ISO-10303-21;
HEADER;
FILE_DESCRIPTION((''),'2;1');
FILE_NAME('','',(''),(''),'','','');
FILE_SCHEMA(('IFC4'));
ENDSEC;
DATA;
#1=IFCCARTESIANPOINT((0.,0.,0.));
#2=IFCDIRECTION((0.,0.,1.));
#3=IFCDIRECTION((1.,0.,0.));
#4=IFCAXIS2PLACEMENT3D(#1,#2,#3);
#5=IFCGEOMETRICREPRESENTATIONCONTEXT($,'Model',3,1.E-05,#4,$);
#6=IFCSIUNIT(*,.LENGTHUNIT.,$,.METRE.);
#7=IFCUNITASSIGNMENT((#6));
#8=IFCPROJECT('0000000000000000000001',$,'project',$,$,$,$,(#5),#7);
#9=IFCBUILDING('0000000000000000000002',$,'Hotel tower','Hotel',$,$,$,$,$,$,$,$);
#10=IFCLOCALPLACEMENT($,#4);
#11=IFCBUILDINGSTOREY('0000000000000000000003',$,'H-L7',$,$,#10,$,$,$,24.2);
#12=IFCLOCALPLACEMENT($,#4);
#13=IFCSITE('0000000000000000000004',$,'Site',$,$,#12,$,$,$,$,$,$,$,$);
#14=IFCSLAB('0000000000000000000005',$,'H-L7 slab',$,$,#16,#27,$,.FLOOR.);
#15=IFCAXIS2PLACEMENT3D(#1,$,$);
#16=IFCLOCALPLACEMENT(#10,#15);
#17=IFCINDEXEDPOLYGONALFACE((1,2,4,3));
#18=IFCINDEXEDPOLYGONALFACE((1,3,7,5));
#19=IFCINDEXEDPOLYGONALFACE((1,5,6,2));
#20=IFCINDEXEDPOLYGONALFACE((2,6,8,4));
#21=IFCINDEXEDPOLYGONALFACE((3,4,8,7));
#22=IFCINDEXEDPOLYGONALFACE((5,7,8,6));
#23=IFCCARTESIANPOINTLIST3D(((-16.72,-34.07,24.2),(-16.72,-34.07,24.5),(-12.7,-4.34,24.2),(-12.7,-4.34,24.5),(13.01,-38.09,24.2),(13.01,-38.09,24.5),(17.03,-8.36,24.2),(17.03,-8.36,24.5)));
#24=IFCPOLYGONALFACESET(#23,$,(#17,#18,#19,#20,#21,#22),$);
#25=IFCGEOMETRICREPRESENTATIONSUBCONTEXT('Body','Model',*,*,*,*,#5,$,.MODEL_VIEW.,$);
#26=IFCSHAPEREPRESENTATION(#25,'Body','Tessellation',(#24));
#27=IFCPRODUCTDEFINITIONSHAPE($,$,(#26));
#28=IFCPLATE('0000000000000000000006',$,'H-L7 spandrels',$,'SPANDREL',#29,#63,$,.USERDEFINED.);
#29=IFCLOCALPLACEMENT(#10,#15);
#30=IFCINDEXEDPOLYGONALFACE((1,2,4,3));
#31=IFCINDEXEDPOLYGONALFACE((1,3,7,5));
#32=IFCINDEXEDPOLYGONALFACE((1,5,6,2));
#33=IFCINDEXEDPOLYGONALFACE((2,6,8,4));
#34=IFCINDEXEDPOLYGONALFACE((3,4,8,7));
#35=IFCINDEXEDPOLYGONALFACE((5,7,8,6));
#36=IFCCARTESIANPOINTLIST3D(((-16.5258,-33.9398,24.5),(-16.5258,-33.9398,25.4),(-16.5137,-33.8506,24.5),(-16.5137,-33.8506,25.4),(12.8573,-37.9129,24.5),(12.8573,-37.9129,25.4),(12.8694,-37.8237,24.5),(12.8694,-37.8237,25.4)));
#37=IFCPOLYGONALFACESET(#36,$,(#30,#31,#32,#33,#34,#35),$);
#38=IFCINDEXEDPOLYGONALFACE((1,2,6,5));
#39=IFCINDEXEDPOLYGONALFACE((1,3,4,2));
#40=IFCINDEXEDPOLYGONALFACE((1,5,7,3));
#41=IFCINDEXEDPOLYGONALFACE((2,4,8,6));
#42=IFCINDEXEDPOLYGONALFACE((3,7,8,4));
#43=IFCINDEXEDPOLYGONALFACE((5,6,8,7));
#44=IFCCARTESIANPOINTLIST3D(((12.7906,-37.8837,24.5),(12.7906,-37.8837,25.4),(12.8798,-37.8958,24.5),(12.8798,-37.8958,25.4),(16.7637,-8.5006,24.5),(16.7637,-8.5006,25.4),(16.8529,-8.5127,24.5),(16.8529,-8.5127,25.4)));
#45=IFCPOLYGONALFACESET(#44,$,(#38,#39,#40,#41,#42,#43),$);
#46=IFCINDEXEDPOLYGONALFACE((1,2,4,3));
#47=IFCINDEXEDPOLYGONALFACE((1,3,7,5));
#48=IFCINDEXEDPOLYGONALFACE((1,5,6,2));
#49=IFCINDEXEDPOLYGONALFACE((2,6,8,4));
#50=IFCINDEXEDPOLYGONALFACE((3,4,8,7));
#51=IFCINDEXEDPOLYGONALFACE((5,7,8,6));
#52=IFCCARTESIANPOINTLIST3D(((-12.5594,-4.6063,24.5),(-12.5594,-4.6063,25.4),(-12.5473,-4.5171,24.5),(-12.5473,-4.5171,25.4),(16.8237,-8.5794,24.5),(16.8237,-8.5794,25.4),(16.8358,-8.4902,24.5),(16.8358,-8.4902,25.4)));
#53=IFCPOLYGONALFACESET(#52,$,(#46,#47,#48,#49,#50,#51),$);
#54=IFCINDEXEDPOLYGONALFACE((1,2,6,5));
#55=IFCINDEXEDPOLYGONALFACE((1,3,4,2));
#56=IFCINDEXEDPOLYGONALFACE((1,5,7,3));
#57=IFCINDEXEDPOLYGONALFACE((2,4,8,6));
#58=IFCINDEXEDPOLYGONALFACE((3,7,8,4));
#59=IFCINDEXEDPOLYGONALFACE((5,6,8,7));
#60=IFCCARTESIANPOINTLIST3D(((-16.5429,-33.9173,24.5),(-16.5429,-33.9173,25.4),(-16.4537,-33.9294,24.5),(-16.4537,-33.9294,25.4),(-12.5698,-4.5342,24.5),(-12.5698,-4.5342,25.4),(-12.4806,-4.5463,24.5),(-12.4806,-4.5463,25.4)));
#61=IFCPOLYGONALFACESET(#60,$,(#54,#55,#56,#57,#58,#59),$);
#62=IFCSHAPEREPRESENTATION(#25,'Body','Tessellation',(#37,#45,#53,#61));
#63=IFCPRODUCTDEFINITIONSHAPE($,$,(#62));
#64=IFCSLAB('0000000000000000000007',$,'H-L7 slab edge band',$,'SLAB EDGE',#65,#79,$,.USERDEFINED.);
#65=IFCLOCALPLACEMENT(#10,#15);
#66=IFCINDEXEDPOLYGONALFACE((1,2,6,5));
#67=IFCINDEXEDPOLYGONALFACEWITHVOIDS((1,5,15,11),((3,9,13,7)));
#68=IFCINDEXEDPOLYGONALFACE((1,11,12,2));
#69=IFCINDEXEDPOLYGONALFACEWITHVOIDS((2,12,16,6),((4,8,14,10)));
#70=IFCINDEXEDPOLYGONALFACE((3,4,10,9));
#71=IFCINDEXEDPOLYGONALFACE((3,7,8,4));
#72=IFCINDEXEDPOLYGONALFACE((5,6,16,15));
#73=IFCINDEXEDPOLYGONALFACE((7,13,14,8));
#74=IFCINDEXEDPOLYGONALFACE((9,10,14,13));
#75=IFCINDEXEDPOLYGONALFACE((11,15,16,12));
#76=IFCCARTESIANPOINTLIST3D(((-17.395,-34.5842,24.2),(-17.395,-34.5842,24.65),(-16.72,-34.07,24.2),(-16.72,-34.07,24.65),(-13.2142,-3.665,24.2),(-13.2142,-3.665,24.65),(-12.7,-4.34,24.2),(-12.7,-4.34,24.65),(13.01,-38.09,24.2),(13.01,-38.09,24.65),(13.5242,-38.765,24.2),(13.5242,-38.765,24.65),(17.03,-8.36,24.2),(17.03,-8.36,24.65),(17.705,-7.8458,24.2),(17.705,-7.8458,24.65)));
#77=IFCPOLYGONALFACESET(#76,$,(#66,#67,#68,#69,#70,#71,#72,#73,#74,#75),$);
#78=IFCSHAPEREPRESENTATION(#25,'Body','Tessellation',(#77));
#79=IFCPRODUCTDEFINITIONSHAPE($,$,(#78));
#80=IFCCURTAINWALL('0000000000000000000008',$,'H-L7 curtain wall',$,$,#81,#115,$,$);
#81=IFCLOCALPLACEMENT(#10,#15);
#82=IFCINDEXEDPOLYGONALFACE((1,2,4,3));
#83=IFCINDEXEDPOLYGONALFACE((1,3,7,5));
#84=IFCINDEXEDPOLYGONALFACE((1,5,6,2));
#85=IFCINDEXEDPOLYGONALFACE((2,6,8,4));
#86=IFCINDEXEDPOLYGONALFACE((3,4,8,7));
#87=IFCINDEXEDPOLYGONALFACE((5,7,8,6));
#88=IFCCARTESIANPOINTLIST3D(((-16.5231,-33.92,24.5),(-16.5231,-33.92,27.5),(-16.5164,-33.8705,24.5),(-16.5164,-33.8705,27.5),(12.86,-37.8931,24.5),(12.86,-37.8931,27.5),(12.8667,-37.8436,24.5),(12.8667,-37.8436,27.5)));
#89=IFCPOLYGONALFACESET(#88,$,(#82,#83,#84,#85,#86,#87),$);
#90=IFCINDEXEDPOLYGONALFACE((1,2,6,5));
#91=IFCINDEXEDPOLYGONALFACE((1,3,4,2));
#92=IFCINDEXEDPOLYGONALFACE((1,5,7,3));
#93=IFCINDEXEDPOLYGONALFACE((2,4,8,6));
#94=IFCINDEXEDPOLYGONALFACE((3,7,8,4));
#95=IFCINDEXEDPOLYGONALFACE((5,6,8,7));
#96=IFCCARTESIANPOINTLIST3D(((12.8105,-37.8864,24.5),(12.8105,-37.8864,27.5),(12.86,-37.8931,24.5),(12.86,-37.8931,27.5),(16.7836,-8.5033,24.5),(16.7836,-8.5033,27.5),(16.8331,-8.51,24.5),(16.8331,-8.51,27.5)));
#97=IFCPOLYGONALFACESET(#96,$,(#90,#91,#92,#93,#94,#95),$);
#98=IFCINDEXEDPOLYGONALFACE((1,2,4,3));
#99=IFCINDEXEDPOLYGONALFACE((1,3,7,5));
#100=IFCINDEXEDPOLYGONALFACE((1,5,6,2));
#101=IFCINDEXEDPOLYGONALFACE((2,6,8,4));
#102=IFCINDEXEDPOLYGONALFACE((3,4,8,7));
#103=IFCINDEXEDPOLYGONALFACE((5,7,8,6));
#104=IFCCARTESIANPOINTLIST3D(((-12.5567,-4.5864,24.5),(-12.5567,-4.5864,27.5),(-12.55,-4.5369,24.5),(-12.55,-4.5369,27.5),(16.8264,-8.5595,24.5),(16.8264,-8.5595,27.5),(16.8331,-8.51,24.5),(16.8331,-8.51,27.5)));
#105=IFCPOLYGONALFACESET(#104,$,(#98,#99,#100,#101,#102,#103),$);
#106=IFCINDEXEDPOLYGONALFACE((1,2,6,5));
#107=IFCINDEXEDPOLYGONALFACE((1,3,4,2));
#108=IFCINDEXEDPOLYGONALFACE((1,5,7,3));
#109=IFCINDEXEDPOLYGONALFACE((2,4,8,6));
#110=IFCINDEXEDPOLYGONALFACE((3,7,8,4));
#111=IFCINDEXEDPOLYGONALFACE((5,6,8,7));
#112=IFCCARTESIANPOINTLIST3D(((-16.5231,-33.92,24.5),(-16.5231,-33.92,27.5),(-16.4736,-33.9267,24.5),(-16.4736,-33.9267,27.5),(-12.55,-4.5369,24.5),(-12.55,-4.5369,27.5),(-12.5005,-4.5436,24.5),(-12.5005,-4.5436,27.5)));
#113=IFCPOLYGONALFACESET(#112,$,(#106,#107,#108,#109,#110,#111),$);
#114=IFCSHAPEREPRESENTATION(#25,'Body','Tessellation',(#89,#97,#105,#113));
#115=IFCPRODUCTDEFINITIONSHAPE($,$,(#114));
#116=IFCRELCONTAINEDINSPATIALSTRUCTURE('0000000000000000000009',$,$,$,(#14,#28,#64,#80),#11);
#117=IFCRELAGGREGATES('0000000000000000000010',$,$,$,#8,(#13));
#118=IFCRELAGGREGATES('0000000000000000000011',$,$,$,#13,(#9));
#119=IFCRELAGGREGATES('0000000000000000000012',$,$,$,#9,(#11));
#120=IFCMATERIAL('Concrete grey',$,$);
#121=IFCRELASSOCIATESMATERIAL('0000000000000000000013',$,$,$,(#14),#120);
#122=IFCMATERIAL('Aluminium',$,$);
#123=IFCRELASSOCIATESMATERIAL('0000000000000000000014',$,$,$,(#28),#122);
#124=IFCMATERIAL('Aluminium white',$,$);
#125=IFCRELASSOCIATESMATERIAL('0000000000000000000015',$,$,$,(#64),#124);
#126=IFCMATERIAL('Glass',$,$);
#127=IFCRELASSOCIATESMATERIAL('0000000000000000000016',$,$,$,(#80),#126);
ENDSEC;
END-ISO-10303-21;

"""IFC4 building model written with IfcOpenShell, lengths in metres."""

from ifc_helpers import new_model, si_unit, frame, origin_with_axes, place, context, subcontext, project, spatial, polyline, outline, extrude, material, element, save


model = new_model("IFC4")

# Units and contexts
model_context = context("Model", 3, precision=1e-05, world=origin_with_axes())
body_context = subcontext(model_context, "Body", "Model", "MODEL_VIEW")
ifc_project = project(units=[si_unit("LENGTHUNIT", "METRE")], contexts=[model_context])

# Site, building, storey
site_placement = place(None, origin_with_axes())
site = spatial("IfcSite", under=ifc_project, at=site_placement, Name="Site")
building = spatial("IfcBuilding", under=site, Name="Hotel tower", Description="Hotel")
storey_placement = place(None, origin_with_axes())
storey = spatial("IfcBuildingStorey", under=building, at=storey_placement, Name="H-L7", Elevation=24.2)

# Shared definitions
ifc_material_1 = material(Name="Aluminium")

# Slab
ifc_material_2 = material(Name="Concrete grey")
slab_1_placement = place(storey_placement, origin_with_axes())
element("IfcSlab", 1, at=slab_1_placement, inside=storey, material=ifc_material_2, Name="H-L7 slab", PredefinedType="FLOOR", context=body_context, shape_type="SweptSolid", body=[
    extrude(outline(polyline([(-16.72, -34.07), (13.01, -38.09), (17.03, -8.36), (-12.7, -4.34), (-16.72, -34.07)])), frame((0.0, 0.0, 24.2), z_axis=(0.0, 0.0, 1.0), x_axis=(1.0, 0.0, 0.0)), (0.0, 0.0, 1.0), 0.3),
])

# Plate
plate_placement = place(storey_placement, origin_with_axes())
element("IfcPlate", 2, at=plate_placement, inside=storey, material=ifc_material_1, Name="H-L7 spandrels", ObjectType="SPANDREL", PredefinedType="USERDEFINED", context=body_context, shape_type="SweptSolid", body=[
    extrude(outline(polyline([(-16.5258, -33.9398), (12.8573, -37.9129), (12.8694, -37.8237), (-16.5137, -33.8506), (-16.5258, -33.9398)])), frame((0.0, 0.0, 24.5), z_axis=(0.0, 0.0, 1.0), x_axis=(1.0, 0.0, 0.0)), (0.0, 0.0, 1.0), 0.9),
    extrude(outline(polyline([(12.8798, -37.8958), (16.8529, -8.5127), (16.7637, -8.5006), (12.7906, -37.8837), (12.8798, -37.8958)])), frame((0.0, 0.0, 24.5), z_axis=(0.0, 0.0, 1.0), x_axis=(1.0, 0.0, 0.0)), (0.0, 0.0, 1.0), 0.9),
    extrude(outline(polyline([(16.8358, -8.4902), (-12.5473, -4.5171), (-12.5594, -4.6063), (16.8237, -8.5794), (16.8358, -8.4902)])), frame((0.0, 0.0, 24.5), z_axis=(0.0, 0.0, 1.0), x_axis=(1.0, 0.0, 0.0)), (0.0, 0.0, 1.0), 0.9),
    extrude(outline(polyline([(-12.5698, -4.5342), (-16.5429, -33.9173), (-16.4537, -33.9294), (-12.4806, -4.5463), (-12.5698, -4.5342)])), frame((0.0, 0.0, 24.5), z_axis=(0.0, 0.0, 1.0), x_axis=(1.0, 0.0, 0.0)), (0.0, 0.0, 1.0), 0.9),
])

# Slab
ifc_material_3 = material(Name="Aluminium white")
slab_2_placement = place(storey_placement, origin_with_axes())
element("IfcSlab", 3, at=slab_2_placement, inside=storey, material=ifc_material_3, Name="H-L7 slab edge band", ObjectType="SLAB EDGE", PredefinedType="USERDEFINED", context=body_context, shape_type="SweptSolid", body=[
    extrude(outline(polyline([(-17.395, -34.5842), (13.5242, -38.765), (17.705, -7.8458), (-13.2142, -3.665), (-17.395, -34.5842)]), holes=[polyline([(-16.72, -34.07), (13.01, -38.09), (17.03, -8.36), (-12.7, -4.34), (-16.72, -34.07)])]), frame((0.0, 0.0, 24.2), z_axis=(0.0, 0.0, 1.0), x_axis=(1.0, 0.0, 0.0)), (0.0, 0.0, 1.0), 0.45),
])

# Curtain wall
ifc_material_4 = material(Name="Glass")
curtain_wall_placement = place(storey_placement, origin_with_axes())
element("IfcCurtainWall", 4, at=curtain_wall_placement, inside=storey, material=ifc_material_4, Name="H-L7 curtain wall", context=body_context, shape_type="SweptSolid", body=[
    extrude(outline(polyline([(-16.5231, -33.92), (12.86, -37.8931), (12.8667, -37.8436), (-16.5164, -33.8705), (-16.5231, -33.92)])), frame((0.0, 0.0, 24.5), z_axis=(0.0, 0.0, 1.0), x_axis=(1.0, 0.0, 0.0)), (0.0, 0.0, 1.0), 3.0),
    extrude(outline(polyline([(12.86, -37.8931), (16.8331, -8.51), (16.7836, -8.5033), (12.8105, -37.8864), (12.86, -37.8931)])), frame((0.0, 0.0, 24.5), z_axis=(0.0, 0.0, 1.0), x_axis=(1.0, 0.0, 0.0)), (0.0, 0.0, 1.0), 3.0),
    extrude(outline(polyline([(16.8331, -8.51), (-12.55, -4.5369), (-12.5567, -4.5864), (16.8264, -8.5595), (16.8331, -8.51)])), frame((0.0, 0.0, 24.5), z_axis=(0.0, 0.0, 1.0), x_axis=(1.0, 0.0, 0.0)), (0.0, 0.0, 1.0), 3.0),
    extrude(outline(polyline([(-12.55, -4.5369), (-16.5231, -33.92), (-16.4736, -33.9267), (-12.5005, -4.5436), (-12.55, -4.5369)])), frame((0.0, 0.0, 24.5), z_axis=(0.0, 0.0, 1.0), x_axis=(1.0, 0.0, 0.0)), (0.0, 0.0, 1.0), 3.0),
])

save(model, "model.ifc")
